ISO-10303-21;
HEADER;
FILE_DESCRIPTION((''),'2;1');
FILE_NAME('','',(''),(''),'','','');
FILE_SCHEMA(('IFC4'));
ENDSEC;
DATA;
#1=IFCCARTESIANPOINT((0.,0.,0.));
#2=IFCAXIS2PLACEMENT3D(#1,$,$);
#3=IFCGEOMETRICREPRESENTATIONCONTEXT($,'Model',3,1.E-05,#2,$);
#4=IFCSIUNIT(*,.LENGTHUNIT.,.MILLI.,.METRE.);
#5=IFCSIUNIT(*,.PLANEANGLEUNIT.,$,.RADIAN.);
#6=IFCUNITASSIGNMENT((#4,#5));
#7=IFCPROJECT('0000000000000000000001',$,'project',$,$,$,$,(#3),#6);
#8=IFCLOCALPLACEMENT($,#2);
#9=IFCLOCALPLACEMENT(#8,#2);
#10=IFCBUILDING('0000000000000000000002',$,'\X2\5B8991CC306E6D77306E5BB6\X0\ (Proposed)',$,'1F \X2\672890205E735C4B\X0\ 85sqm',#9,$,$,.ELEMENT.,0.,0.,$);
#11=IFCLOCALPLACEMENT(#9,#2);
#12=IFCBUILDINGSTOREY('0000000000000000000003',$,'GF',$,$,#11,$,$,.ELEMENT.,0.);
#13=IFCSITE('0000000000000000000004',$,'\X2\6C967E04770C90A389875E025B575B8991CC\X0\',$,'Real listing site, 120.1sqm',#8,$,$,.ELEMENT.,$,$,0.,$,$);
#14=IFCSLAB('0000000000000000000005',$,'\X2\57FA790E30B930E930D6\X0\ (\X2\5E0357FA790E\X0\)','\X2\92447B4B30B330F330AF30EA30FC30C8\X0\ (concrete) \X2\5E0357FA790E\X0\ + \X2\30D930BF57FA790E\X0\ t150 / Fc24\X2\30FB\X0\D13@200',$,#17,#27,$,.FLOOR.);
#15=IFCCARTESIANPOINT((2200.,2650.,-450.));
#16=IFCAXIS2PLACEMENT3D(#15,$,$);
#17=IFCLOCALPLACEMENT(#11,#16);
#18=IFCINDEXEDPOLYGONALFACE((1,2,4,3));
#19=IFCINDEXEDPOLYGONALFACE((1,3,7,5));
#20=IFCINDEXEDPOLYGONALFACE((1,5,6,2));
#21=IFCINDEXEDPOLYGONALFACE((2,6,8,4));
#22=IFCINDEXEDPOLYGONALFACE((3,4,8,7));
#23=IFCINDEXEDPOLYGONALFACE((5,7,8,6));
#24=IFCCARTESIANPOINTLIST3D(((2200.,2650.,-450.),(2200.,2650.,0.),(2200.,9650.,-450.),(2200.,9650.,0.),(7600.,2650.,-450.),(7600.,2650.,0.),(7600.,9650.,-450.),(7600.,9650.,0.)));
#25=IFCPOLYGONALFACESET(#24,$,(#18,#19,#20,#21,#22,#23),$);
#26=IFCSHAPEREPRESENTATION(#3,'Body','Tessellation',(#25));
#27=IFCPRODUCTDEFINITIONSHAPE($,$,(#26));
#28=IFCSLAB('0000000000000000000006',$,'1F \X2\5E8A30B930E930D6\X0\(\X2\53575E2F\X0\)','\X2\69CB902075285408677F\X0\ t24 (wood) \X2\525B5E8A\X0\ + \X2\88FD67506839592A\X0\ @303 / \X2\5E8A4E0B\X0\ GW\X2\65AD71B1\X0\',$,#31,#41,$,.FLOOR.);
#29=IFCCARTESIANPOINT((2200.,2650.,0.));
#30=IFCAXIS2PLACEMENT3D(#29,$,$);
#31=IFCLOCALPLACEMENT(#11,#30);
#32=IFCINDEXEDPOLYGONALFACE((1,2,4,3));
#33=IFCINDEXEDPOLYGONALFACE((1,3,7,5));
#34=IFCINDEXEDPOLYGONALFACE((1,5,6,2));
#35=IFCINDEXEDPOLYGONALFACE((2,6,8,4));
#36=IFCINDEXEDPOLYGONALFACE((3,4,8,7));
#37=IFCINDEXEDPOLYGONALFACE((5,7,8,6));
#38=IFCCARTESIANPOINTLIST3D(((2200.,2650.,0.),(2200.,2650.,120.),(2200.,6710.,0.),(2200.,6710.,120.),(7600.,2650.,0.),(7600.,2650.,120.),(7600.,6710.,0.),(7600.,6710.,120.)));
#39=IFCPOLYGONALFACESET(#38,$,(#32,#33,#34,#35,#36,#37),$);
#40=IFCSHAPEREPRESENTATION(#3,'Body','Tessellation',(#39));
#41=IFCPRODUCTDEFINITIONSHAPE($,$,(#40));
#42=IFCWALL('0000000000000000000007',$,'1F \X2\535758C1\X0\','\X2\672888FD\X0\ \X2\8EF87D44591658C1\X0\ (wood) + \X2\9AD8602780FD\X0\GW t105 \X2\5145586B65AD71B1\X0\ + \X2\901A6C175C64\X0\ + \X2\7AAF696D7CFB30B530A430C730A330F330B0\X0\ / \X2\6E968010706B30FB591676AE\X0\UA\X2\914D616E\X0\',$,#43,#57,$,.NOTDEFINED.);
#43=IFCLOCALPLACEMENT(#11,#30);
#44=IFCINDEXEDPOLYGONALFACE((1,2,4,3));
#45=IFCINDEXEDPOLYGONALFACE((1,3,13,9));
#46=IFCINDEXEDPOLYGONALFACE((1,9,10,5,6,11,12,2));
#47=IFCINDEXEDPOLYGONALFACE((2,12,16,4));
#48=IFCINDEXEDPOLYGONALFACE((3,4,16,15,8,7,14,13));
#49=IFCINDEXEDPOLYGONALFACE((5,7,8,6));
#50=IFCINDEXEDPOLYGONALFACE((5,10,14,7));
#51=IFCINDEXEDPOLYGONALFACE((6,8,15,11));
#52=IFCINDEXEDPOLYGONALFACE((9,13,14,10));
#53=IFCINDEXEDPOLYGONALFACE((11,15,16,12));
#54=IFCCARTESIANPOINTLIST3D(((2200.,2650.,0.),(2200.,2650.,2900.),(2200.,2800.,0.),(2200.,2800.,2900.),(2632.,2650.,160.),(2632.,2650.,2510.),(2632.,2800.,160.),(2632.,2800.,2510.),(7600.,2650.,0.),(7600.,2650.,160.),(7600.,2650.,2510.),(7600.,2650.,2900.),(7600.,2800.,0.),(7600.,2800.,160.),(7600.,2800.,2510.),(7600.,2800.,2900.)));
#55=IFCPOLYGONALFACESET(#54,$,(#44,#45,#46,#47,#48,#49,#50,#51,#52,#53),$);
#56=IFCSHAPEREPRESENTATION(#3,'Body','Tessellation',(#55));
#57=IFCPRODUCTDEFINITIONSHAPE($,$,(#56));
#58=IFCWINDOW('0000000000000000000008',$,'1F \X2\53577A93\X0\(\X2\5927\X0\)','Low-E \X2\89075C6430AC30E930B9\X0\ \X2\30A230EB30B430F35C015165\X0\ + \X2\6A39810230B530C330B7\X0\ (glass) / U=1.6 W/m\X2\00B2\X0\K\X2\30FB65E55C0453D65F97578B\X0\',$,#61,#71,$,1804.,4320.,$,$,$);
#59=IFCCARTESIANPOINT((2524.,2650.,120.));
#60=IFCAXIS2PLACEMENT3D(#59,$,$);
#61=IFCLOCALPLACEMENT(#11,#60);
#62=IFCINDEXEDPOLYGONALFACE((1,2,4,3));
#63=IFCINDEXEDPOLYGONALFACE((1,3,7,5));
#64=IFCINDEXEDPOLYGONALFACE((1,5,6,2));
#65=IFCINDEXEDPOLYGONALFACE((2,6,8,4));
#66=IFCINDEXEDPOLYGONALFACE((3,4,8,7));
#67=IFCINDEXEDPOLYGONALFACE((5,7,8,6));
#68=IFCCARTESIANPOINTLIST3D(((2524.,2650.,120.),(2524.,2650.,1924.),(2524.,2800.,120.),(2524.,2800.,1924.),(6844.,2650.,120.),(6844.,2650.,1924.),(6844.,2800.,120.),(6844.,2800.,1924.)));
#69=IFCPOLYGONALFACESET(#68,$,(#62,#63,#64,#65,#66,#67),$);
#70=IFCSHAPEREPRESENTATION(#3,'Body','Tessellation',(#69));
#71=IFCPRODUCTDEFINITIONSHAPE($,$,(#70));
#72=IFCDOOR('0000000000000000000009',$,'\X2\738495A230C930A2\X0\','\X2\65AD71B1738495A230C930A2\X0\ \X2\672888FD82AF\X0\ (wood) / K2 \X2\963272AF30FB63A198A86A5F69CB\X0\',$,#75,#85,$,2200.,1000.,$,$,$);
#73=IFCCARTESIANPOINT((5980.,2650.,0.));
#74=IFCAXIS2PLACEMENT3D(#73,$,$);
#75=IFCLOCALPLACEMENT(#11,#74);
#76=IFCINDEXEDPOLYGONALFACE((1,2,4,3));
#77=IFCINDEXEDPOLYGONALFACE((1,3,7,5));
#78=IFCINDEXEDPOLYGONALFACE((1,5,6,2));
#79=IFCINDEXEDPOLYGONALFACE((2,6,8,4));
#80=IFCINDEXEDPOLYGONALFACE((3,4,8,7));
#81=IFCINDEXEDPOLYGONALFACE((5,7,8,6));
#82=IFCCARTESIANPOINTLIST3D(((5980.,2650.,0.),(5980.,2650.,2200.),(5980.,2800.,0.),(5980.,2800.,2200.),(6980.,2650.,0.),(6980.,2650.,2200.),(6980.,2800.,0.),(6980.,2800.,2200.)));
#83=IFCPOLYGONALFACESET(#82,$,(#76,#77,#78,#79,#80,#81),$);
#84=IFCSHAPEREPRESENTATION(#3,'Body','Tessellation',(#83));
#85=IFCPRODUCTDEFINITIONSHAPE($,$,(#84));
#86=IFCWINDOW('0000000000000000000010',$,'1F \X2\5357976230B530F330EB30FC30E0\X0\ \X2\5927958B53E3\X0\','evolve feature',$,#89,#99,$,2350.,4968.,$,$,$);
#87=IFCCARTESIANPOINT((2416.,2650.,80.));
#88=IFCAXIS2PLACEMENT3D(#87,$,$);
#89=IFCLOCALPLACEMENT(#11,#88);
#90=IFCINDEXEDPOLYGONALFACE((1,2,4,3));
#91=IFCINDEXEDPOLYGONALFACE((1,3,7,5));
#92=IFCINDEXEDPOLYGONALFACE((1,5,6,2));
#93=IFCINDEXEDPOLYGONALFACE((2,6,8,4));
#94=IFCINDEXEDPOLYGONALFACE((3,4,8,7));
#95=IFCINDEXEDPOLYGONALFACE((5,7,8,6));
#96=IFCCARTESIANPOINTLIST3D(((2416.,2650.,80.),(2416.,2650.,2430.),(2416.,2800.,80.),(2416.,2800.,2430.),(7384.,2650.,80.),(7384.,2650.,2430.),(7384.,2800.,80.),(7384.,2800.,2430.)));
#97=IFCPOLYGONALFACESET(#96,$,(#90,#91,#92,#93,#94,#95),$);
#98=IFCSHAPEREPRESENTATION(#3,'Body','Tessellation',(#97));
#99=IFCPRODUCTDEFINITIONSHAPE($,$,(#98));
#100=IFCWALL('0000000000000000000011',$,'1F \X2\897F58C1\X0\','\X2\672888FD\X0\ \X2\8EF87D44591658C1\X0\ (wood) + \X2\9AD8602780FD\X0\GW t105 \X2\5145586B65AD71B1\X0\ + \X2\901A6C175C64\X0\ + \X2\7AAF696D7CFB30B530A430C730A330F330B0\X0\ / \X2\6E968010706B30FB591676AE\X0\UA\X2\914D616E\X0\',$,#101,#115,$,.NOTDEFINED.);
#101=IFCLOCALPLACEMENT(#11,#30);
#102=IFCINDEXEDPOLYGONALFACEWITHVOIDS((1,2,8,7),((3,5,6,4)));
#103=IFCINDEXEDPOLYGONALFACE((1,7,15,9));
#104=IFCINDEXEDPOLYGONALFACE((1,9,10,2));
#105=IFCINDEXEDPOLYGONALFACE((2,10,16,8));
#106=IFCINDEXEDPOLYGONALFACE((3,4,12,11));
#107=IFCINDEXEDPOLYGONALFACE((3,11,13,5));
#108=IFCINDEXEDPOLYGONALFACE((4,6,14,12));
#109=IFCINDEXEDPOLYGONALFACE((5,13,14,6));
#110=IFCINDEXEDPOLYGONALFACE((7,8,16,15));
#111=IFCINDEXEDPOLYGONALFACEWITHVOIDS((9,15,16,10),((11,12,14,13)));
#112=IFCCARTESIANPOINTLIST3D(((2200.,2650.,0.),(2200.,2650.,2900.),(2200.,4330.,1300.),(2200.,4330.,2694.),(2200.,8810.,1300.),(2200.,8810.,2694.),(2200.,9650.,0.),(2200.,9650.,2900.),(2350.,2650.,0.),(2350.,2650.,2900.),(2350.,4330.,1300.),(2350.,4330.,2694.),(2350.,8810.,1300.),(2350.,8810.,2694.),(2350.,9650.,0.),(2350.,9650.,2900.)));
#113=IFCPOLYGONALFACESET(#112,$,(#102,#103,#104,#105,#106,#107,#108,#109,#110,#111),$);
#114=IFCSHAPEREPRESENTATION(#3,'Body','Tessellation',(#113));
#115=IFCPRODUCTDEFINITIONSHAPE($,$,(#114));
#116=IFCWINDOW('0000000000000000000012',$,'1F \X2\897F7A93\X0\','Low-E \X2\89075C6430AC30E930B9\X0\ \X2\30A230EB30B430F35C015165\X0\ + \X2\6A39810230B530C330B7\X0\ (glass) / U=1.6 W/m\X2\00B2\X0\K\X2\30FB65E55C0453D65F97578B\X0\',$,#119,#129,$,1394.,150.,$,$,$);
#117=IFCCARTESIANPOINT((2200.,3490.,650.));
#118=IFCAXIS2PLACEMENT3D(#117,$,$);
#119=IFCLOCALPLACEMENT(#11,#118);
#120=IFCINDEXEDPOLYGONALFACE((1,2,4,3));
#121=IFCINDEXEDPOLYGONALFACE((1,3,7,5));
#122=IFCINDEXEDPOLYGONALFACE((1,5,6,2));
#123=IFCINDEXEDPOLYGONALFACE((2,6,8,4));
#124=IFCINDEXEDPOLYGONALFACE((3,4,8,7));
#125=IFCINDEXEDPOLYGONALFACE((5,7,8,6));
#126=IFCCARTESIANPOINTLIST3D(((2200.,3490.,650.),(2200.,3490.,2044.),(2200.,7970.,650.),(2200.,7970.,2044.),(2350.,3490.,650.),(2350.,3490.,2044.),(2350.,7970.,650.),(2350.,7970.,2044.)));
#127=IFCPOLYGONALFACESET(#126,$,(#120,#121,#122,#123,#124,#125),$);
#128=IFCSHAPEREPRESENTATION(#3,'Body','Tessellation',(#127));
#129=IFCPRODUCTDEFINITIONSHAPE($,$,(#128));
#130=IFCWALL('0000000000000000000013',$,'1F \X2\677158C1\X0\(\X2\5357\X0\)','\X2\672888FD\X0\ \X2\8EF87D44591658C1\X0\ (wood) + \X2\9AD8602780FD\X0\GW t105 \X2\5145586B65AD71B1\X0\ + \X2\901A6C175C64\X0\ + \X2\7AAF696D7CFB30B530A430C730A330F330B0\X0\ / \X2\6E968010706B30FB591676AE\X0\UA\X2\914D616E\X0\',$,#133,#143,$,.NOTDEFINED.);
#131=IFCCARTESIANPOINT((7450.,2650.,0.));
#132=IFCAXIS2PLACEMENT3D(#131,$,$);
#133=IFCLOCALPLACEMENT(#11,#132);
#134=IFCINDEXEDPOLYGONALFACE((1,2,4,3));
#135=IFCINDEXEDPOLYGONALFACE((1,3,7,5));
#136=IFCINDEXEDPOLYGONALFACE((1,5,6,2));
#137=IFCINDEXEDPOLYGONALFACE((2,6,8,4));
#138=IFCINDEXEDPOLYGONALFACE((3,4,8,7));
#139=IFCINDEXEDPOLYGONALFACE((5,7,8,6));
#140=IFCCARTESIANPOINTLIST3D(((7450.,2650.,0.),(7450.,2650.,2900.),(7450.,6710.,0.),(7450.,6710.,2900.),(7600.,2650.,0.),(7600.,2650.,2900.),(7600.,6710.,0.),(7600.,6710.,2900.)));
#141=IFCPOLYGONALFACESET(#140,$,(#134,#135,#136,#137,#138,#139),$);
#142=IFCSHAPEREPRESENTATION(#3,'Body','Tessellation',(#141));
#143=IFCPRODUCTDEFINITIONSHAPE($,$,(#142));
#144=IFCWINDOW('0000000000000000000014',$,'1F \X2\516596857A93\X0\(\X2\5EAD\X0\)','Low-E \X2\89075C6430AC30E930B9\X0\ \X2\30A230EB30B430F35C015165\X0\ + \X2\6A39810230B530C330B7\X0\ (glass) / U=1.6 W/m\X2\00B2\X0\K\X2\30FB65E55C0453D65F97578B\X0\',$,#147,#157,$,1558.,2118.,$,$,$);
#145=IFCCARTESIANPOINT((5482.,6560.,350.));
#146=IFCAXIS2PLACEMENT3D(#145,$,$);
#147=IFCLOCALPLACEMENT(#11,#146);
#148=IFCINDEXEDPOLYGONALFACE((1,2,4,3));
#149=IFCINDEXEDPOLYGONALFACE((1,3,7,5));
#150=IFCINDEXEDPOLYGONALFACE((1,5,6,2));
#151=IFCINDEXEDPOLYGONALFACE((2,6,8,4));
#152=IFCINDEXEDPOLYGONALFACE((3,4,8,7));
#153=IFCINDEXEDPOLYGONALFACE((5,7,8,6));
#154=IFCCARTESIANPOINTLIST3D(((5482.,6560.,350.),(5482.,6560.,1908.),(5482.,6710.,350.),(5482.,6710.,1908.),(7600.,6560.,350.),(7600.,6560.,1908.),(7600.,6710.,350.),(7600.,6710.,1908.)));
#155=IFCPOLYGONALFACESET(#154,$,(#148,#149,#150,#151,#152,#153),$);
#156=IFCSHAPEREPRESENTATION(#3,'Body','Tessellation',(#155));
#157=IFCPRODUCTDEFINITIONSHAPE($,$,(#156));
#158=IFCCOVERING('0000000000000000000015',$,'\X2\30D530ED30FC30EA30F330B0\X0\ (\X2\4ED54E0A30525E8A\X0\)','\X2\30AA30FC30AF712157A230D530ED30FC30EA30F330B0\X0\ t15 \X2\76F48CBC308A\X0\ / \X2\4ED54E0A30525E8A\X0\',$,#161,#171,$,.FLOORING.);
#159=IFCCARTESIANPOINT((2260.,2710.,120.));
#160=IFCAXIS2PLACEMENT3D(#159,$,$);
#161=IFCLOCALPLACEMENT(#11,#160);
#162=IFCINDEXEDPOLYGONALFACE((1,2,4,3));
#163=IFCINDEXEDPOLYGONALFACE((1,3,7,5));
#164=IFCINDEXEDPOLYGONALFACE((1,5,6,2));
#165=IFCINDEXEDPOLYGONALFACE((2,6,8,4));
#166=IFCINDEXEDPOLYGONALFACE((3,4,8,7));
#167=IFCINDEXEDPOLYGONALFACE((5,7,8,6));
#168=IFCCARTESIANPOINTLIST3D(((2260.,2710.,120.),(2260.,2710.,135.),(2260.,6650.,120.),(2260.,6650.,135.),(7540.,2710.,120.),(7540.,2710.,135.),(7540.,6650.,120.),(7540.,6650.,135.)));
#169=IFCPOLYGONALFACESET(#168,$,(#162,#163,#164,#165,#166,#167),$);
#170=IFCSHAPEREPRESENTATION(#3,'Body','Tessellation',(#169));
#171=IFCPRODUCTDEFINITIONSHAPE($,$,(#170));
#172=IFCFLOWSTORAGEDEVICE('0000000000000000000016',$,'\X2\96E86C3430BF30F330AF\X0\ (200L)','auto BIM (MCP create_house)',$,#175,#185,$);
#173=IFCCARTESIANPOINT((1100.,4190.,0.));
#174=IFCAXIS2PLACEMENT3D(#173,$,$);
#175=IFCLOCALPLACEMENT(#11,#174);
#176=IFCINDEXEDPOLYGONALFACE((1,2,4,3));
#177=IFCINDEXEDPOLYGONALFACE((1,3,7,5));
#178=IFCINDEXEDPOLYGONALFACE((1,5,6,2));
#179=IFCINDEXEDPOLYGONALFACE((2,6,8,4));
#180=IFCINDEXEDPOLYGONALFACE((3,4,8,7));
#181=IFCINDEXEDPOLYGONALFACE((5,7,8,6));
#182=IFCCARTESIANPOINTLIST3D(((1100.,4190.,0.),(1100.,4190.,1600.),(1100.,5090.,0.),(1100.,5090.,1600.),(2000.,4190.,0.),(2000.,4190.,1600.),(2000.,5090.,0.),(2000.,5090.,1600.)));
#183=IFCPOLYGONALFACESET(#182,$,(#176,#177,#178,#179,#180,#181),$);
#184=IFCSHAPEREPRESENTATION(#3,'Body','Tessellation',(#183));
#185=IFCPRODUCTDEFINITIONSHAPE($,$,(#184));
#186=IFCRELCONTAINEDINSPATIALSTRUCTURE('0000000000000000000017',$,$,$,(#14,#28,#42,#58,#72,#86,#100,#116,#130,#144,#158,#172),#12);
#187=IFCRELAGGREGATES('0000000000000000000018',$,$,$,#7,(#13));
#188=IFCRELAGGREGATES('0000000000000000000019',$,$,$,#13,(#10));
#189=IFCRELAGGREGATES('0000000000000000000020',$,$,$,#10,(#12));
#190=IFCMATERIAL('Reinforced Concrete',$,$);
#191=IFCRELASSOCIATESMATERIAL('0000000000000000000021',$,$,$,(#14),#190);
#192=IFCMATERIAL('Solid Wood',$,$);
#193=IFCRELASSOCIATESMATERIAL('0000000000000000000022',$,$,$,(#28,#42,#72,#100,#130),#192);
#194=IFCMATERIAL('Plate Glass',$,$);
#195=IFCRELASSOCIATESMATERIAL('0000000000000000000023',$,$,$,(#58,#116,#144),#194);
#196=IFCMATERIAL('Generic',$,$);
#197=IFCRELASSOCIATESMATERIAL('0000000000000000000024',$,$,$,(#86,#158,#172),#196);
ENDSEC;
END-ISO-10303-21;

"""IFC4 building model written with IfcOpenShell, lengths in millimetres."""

from ifc_helpers import new_model, si_unit, frame, frame_2d, origin, place, context, project, spatial, rectangle, extrude, material, element, fill, save


model = new_model("IFC4")

# Units and contexts
model_context = context("Model", 3, precision=1e-05, world=origin())
ifc_project = project(units=[si_unit("LENGTHUNIT", "METRE", prefix="MILLI"), si_unit("PLANEANGLEUNIT", "RADIAN")], contexts=[model_context])

# Site, building, storey
site_placement = place(None, origin())
site = spatial("IfcSite", under=ifc_project, at=site_placement, Name="沖縄県那覇市字安里", ObjectType="Real listing site, 120.1sqm", CompositionType="ELEMENT", RefElevation=0.0)
building_placement = place(site_placement, origin())
building = spatial("IfcBuilding", under=site, at=building_placement, Name="安里の海の家 (Proposed)", ObjectType="1F 木造平屋 85sqm", CompositionType="ELEMENT", ElevationOfRefHeight=0.0, ElevationOfTerrain=0.0)
storey_placement = place(building_placement, origin())
storey = spatial("IfcBuildingStorey", under=building, at=storey_placement, Name="GF", CompositionType="ELEMENT", Elevation=0.0)

# Slabs
ifc_material_1 = material(Name="Reinforced Concrete")
slab_1_placement = place(storey_placement, frame((2200.0, 2650.0, -450.0)))
element("IfcSlab", 1, at=slab_1_placement, inside=storey, material=ifc_material_1, Name="基礎スラブ (布基礎)", Description="鉄筋コンクリート (concrete) 布基礎 + ベタ基礎 t150 / Fc24・D13@200", PredefinedType="FLOOR", context=model_context, shape_type="SweptSolid", body=[
    extrude(rectangle(XDim=5400.0, YDim=7000.0, at=frame_2d((2700.0, 3500.0))), frame((2200.0, 2650.0, -450.0)), (0.0, 0.0, 1.0), 450.0),
])
ifc_material_2 = material(Name="Solid Wood")
slab_2_placement = place(storey_placement, frame((2200.0, 2650.0, 0.0)))
element("IfcSlab", 2, at=slab_2_placement, inside=storey, material=ifc_material_2, Name="1F 床スラブ(南帯)", Description="構造用合板 t24 (wood) 剛床 + 製材根太 @303 / 床下 GW断熱", PredefinedType="FLOOR", context=model_context, shape_type="SweptSolid", body=[
    extrude(rectangle(XDim=5400.0, YDim=4060.0, at=frame_2d((2700.0, 2030.0))), frame((2200.0, 2650.0, 0.0)), (0.0, 0.0, 1.0), 120.0),
])

# Wall, openings, windows, door
wall_1_placement = place(storey_placement, frame((2200.0, 2650.0, 0.0)))
wall_1 = element("IfcWall", 3, at=wall_1_placement, inside=storey, material=ifc_material_2, Name="1F 南壁", Description="木製 軸組外壁 (wood) + 高性能GW t105 充填断熱 + 通気層 + 窯業系サイディング / 準耐火・外皮UA配慮", PredefinedType="NOTDEFINED", context=model_context, shape_type="SweptSolid", body=[
    extrude(rectangle(XDim=5400.0, YDim=150.0, at=frame_2d((2700.0, 75.0))), frame((2200.0, 2650.0, 0.0)), (0.0, 0.0, 1.0), 2900.0),
])
opening_1_placement = place(storey_placement, frame((2524.0, 2650.0, 120.0)))
opening_1 = element("IfcOpeningElement", 4, at=opening_1_placement, cuts=wall_1, PredefinedType="NOTDEFINED", context=model_context, shape_type="SweptSolid", body=[
    extrude(rectangle(XDim=4320.0, YDim=150.0, at=frame_2d((2160.0, 75.0))), frame((2524.0, 2650.0, 120.0)), (0.0, 0.0, 1.0), 1804.0),
])
opening_2_placement = place(storey_placement, frame((5980.0, 2650.0, 0.0)))
opening_2 = element("IfcOpeningElement", 5, at=opening_2_placement, cuts=wall_1, PredefinedType="NOTDEFINED", context=model_context, shape_type="SweptSolid", body=[
    extrude(rectangle(XDim=1000.0, YDim=150.0, at=frame_2d((500.0, 75.0))), frame((5980.0, 2650.0, 0.0)), (0.0, 0.0, 1.0), 2200.0),
])
opening_3_placement = place(storey_placement, frame((2416.0, 2650.0, 80.0)))
opening_3 = element("IfcOpeningElement", 6, at=opening_3_placement, cuts=wall_1, PredefinedType="NOTDEFINED", context=model_context, shape_type="SweptSolid", body=[
    extrude(rectangle(XDim=4968.0, YDim=150.0, at=frame_2d((2484.0, 75.0))), frame((2416.0, 2650.0, 80.0)), (0.0, 0.0, 1.0), 2350.0),
])
ifc_material_3 = material(Name="Plate Glass")
window_1_placement = place(storey_placement, frame((2524.0, 2650.0, 120.0)))
window_1 = element("IfcWindow", 7, at=window_1_placement, inside=storey, material=ifc_material_3, Name="1F 南窓(大)", Description="Low-E 複層ガラス アルゴン封入 + 樹脂サッシ (glass) / U=1.6 W/m²K・日射取得型", OverallHeight=1804.0, OverallWidth=4320.0, context=model_context, shape_type="SweptSolid", body=[
    extrude(rectangle(XDim=4320.0, YDim=150.0, at=frame_2d((2160.0, 75.0))), frame((2524.0, 2650.0, 120.0)), (0.0, 0.0, 1.0), 1804.0),
])
fill(opening_1, window_1)
door_1_placement = place(storey_placement, frame((5980.0, 2650.0, 0.0)))
door_1 = element("IfcDoor", 8, at=door_1_placement, inside=storey, material=ifc_material_2, Name="玄関ドア", Description="断熱玄関ドア 木製芯 (wood) / K2 防犯・採風機構", OverallHeight=2200.0, OverallWidth=1000.0, context=model_context, shape_type="SweptSolid", body=[
    extrude(rectangle(XDim=1000.0, YDim=150.0, at=frame_2d((500.0, 75.0))), frame((5980.0, 2650.0, 0.0)), (0.0, 0.0, 1.0), 2200.0),
])
fill(opening_2, door_1)
ifc_material_4 = material(Name="Generic")
window_2_placement = place(storey_placement, frame((2416.0, 2650.0, 80.0)))
window_2 = element("IfcWindow", 9, at=window_2_placement, inside=storey, material=ifc_material_4, Name="1F 南面サンルーム 大開口", Description="evolve feature", OverallHeight=2350.0, OverallWidth=4968.0, context=model_context, shape_type="SweptSolid", body=[
    extrude(rectangle(XDim=4968.0, YDim=150.0, at=frame_2d((2484.0, 75.0))), frame((2416.0, 2650.0, 80.0)), (0.0, 0.0, 1.0), 2350.0),
])
fill(opening_3, window_2)

# Walls, openings, windows
wall_2_placement = place(storey_placement, frame((2200.0, 2650.0, 0.0)))
wall_2 = element("IfcWall", 10, at=wall_2_placement, inside=storey, material=ifc_material_2, Name="1F 西壁", Description="木製 軸組外壁 (wood) + 高性能GW t105 充填断熱 + 通気層 + 窯業系サイディング / 準耐火・外皮UA配慮", PredefinedType="NOTDEFINED", context=model_context, shape_type="SweptSolid", body=[
    extrude(rectangle(XDim=150.0, YDim=7000.0, at=frame_2d((75.0, 3500.0))), frame((2200.0, 2650.0, 0.0)), (0.0, 0.0, 1.0), 2900.0),
])
opening_4_placement = place(storey_placement, frame((2200.0, 3490.0, 650.0)))
opening_4 = element("IfcOpeningElement", 11, at=opening_4_placement, cuts=wall_2, PredefinedType="NOTDEFINED", context=model_context, shape_type="SweptSolid", body=[
    extrude(rectangle(XDim=150.0, YDim=4480.0, at=frame_2d((75.0, 2240.0))), frame((2200.0, 3490.0, 650.0)), (0.0, 0.0, 1.0), 1394.0),
])
window_3_placement = place(storey_placement, frame((2200.0, 3490.0, 650.0)))
window_3 = element("IfcWindow", 12, at=window_3_placement, inside=storey, material=ifc_material_3, Name="1F 西窓", Description="Low-E 複層ガラス アルゴン封入 + 樹脂サッシ (glass) / U=1.6 W/m²K・日射取得型", OverallHeight=1394.0, OverallWidth=150.0, context=model_context, shape_type="SweptSolid", body=[
    extrude(rectangle(XDim=150.0, YDim=4480.0, at=frame_2d((75.0, 2240.0))), frame((2200.0, 3490.0, 650.0)), (0.0, 0.0, 1.0), 1394.0),
])
fill(opening_4, window_3)
wall_3_placement = place(storey_placement, frame((7450.0, 2650.0, 0.0)))
wall_3 = element("IfcWall", 13, at=wall_3_placement, inside=storey, material=ifc_material_2, Name="1F 東壁(南)", Description="木製 軸組外壁 (wood) + 高性能GW t105 充填断熱 + 通気層 + 窯業系サイディング / 準耐火・外皮UA配慮", PredefinedType="NOTDEFINED", context=model_context, shape_type="SweptSolid", body=[
    extrude(rectangle(XDim=150.0, YDim=4060.0, at=frame_2d((75.0, 2030.0))), frame((7450.0, 2650.0, 0.0)), (0.0, 0.0, 1.0), 2900.0),
])
opening_5_placement = place(storey_placement, frame((5482.0, 6560.0, 350.0)))
opening_5 = element("IfcOpeningElement", 14, at=opening_5_placement, cuts=wall_3, PredefinedType="NOTDEFINED", context=model_context, shape_type="SweptSolid", body=[
    extrude(rectangle(XDim=2118.0, YDim=150.0, at=frame_2d((1059.0, 75.0))), frame((5482.0, 6560.0, 350.0)), (0.0, 0.0, 1.0), 1558.0),
])
window_4_placement = place(storey_placement, frame((5482.0, 6560.0, 350.0)))
window_4 = element("IfcWindow", 15, at=window_4_placement, inside=storey, material=ifc_material_3, Name="1F 入隅窓(庭)", Description="Low-E 複層ガラス アルゴン封入 + 樹脂サッシ (glass) / U=1.6 W/m²K・日射取得型", OverallHeight=1558.0, OverallWidth=2118.0, context=model_context, shape_type="SweptSolid", body=[
    extrude(rectangle(XDim=2118.0, YDim=150.0, at=frame_2d((1059.0, 75.0))), frame((5482.0, 6560.0, 350.0)), (0.0, 0.0, 1.0), 1558.0),
])
fill(opening_5, window_4)

# Covering
covering_placement = place(storey_placement, frame((2260.0, 2710.0, 120.0)))
element("IfcCovering", 16, at=covering_placement, inside=storey, material=ifc_material_4, Name="フローリング (仕上げ床)", Description="オーク無垢フローリング t15 直貼り / 仕上げ床", PredefinedType="FLOORING", context=model_context, shape_type="SweptSolid", body=[
    extrude(rectangle(XDim=5280.0, YDim=3940.0, at=frame_2d((2640.0, 1970.0))), frame((2260.0, 2710.0, 120.0)), (0.0, 0.0, 1.0), 15.0),
])

# Flow storage device
flow_storage_device_placement = place(storey_placement, frame((1100.0, 4190.0, 0.0)))
element("IfcFlowStorageDevice", 17, at=flow_storage_device_placement, inside=storey, material=ifc_material_4, Name="雨水タンク (200L)", Description="auto BIM (MCP create_house)", context=model_context, shape_type="SweptSolid", body=[
    extrude(rectangle(XDim=900.0, YDim=900.0, at=frame_2d((450.0, 450.0))), frame((1100.0, 4190.0, 0.0)), (0.0, 0.0, 1.0), 1600.0),
])

save(model, "model.ifc")
